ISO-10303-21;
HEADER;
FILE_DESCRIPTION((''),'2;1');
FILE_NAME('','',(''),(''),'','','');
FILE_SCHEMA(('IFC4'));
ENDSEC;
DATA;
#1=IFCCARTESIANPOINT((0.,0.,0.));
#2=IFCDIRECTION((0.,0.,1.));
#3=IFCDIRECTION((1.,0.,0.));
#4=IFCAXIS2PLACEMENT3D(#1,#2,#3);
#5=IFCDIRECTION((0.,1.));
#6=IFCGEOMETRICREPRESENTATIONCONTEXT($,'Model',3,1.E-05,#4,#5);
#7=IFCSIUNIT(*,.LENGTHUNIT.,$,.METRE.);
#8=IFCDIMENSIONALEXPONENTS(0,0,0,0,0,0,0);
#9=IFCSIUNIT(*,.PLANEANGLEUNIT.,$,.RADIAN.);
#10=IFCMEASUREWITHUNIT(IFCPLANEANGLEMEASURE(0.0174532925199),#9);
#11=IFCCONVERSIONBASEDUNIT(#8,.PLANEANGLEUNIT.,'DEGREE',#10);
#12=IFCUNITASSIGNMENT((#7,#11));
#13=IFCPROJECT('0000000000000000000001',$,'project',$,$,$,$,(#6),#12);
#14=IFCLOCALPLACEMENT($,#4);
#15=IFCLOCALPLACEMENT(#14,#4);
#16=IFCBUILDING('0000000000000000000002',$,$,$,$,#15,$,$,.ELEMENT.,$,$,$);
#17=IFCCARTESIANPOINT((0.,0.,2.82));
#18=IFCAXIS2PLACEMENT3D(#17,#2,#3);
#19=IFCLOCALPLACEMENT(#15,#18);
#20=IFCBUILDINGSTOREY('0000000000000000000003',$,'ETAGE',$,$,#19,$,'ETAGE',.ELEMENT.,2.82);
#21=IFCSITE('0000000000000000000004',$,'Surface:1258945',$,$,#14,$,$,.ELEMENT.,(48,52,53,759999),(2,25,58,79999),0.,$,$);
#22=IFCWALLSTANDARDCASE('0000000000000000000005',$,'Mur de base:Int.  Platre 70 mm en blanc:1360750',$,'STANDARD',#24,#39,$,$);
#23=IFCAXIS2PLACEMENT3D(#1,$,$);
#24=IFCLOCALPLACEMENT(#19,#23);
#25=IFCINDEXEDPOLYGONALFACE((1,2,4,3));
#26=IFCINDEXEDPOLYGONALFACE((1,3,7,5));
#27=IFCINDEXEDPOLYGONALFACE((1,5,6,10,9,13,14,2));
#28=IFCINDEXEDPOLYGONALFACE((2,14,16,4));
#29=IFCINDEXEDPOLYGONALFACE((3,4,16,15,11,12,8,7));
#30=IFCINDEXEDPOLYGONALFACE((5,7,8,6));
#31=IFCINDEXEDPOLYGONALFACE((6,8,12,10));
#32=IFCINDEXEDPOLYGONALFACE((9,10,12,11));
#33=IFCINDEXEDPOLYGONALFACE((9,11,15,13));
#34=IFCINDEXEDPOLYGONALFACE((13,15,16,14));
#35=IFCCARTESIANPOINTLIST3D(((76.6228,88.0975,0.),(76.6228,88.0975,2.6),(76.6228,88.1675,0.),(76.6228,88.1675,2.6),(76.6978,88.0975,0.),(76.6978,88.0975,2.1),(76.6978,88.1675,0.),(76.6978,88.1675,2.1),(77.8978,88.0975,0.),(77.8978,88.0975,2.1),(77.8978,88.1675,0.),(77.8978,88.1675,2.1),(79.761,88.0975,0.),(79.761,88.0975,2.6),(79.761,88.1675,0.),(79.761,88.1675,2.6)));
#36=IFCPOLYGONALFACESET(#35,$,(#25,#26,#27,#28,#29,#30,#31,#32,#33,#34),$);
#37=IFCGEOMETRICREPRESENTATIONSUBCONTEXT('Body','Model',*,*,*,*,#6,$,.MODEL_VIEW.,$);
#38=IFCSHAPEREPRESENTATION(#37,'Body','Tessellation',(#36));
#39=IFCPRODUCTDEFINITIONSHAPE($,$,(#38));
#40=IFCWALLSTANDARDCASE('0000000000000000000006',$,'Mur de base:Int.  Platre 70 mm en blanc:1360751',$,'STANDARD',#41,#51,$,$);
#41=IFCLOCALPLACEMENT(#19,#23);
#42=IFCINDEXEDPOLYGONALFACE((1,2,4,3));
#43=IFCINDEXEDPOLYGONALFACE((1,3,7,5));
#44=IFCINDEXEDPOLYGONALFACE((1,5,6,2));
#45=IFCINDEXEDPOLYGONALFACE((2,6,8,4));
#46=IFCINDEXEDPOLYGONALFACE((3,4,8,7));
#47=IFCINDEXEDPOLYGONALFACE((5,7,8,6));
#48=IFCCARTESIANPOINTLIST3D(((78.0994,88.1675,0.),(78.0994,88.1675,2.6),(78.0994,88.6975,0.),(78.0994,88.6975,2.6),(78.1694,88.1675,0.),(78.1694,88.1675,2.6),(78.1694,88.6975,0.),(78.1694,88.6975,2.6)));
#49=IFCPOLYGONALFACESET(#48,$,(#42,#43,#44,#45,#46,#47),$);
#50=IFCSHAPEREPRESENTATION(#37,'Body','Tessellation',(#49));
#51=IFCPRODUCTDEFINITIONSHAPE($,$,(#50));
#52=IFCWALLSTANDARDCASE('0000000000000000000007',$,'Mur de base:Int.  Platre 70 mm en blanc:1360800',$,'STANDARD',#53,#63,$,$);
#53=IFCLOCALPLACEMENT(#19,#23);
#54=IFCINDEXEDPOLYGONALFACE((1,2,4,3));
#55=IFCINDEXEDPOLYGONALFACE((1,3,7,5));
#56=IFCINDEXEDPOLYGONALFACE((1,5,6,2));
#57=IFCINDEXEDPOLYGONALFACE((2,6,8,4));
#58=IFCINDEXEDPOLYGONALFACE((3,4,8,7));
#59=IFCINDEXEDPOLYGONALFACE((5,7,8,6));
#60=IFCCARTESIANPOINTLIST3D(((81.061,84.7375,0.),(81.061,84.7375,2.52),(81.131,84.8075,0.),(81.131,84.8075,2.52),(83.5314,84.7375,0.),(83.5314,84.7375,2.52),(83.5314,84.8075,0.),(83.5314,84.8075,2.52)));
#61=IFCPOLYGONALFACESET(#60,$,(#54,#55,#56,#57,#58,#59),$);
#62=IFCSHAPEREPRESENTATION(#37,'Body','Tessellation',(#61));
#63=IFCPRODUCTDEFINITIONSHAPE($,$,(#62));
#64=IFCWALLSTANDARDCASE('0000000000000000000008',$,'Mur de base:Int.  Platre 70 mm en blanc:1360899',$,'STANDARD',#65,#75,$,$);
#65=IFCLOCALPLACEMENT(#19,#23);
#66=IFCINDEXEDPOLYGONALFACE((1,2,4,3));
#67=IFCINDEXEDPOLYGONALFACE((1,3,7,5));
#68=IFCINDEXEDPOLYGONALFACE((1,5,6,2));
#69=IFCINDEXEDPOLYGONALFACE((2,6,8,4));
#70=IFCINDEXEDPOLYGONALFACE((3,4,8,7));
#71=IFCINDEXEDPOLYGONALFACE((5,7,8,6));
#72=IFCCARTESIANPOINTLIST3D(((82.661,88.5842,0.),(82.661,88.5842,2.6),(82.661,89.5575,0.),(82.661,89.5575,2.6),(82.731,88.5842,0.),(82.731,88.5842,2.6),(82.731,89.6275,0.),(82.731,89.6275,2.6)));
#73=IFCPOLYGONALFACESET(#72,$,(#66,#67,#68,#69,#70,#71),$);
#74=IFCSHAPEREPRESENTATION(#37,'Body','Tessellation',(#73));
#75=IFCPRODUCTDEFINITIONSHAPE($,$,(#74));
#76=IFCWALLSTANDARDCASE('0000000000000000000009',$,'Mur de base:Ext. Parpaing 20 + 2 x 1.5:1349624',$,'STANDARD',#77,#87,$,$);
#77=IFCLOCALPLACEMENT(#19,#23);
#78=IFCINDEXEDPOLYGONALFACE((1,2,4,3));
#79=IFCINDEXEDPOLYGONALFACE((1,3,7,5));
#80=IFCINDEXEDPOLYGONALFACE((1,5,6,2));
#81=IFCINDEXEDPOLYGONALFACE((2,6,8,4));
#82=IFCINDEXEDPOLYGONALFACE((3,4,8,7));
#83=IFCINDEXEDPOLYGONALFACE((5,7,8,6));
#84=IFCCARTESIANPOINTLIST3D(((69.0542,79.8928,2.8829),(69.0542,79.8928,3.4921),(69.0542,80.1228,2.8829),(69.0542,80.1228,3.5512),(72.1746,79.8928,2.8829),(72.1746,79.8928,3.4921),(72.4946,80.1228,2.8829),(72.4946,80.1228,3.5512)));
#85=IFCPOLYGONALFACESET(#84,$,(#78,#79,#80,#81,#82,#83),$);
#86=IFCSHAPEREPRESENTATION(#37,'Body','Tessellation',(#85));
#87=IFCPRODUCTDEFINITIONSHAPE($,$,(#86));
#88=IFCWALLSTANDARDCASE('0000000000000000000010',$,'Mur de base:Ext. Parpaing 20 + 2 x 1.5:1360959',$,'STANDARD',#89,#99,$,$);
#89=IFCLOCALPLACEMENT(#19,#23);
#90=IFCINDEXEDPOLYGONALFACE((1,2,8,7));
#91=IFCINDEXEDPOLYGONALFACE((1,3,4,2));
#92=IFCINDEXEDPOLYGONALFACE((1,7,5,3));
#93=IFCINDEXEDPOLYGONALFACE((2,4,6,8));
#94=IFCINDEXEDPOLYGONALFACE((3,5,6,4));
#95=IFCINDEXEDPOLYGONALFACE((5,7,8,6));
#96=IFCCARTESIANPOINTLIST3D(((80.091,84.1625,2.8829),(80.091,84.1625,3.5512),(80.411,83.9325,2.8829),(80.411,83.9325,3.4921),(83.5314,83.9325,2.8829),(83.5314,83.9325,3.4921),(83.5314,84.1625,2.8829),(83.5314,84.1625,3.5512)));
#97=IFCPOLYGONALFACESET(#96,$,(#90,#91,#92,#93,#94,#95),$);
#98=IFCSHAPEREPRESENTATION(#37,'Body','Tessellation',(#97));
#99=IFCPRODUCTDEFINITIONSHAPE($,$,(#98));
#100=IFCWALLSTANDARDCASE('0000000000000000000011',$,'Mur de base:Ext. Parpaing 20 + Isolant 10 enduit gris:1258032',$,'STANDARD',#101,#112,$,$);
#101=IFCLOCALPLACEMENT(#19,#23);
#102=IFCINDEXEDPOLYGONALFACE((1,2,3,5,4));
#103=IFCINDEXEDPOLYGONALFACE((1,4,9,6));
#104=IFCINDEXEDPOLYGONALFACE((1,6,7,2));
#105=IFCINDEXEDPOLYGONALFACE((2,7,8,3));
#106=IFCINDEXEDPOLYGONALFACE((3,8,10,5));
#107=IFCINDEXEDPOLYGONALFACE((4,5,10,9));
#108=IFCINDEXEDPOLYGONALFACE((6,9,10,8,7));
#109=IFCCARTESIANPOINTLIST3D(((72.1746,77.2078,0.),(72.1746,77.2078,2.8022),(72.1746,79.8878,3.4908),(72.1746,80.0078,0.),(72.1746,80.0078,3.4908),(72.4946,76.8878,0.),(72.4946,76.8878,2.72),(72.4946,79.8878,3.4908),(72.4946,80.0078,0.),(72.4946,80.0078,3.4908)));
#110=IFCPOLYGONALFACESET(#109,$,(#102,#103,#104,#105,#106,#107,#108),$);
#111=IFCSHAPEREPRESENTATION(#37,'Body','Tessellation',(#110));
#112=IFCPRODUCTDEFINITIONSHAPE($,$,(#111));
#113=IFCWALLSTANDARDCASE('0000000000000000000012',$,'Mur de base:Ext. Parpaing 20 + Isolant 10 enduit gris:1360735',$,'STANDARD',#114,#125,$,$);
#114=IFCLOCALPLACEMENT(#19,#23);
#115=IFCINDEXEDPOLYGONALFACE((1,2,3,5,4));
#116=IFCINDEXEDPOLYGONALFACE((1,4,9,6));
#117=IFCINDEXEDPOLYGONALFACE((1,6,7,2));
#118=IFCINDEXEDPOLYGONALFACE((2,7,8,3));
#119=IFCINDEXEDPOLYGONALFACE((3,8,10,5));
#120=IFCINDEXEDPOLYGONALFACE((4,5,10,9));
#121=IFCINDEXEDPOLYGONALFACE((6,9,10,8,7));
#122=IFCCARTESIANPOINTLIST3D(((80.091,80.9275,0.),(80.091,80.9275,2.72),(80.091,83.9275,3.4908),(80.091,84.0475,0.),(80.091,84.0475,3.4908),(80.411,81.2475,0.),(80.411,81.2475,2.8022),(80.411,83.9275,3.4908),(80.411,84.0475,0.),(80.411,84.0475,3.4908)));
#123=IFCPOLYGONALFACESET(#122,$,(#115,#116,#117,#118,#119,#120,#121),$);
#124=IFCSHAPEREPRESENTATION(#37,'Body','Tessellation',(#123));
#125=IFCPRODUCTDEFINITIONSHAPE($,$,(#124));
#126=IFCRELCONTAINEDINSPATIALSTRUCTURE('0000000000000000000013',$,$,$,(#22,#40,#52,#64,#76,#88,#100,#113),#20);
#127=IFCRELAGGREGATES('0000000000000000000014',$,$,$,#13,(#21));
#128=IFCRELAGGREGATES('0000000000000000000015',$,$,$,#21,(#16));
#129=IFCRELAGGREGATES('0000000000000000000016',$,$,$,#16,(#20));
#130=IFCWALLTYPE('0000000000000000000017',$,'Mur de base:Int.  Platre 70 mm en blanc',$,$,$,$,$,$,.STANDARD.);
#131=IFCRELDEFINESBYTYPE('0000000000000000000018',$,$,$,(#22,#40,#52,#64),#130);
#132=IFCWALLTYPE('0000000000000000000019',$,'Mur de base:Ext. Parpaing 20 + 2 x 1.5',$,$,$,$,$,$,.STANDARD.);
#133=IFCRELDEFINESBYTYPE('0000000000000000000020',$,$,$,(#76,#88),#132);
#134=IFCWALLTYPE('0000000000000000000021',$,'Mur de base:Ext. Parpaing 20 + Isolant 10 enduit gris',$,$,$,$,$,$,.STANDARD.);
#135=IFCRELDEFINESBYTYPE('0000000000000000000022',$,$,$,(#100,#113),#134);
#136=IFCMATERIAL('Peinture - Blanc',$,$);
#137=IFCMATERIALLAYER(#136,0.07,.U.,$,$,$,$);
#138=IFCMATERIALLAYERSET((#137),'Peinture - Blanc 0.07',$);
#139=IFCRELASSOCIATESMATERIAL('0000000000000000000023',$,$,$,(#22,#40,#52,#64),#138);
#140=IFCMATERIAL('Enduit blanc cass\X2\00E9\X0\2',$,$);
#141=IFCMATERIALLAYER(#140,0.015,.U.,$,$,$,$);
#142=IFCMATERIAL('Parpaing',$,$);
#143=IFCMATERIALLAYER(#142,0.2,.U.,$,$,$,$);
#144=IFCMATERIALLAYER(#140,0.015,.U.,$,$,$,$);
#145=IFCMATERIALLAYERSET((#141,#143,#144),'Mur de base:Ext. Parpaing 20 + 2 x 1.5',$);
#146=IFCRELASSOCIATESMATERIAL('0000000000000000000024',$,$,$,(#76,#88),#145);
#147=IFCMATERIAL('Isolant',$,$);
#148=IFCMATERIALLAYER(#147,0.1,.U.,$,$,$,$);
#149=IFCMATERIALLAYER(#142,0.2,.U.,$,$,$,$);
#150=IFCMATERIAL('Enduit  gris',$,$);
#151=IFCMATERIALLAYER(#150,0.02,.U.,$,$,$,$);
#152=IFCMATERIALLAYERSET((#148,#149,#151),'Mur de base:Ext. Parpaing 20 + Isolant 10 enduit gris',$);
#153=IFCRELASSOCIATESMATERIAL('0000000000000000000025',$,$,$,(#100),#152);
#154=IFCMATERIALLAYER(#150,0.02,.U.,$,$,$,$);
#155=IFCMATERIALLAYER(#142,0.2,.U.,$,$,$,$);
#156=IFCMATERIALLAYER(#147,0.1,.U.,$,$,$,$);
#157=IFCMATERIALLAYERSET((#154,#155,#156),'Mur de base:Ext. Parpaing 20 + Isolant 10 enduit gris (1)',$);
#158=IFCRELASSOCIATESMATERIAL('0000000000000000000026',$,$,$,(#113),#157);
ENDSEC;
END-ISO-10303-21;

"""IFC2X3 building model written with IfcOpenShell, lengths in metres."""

from ifc_helpers import new_model, entity, si_unit, converted_unit, direction, frame, origin_with_axes, place, context, subcontext, project, spatial, polyline, outline, extrude, clip, halfspace, material, layer, layer_set, layer_usage, type_object, element, save


model = new_model("IFC2X3")

# Units and contexts
model_context = context("Model", 3, precision=1e-05, world=origin_with_axes(), true_north=direction((0.0, 1.0)))
body_context = subcontext(model_context, "Body", "Model", "MODEL_VIEW")
ifc_project = project(units=[si_unit("LENGTHUNIT", "METRE"), converted_unit("PLANEANGLEUNIT", "DEGREE", entity("IfcPlaneAngleMeasure", 0.0174532925199), si_unit("PLANEANGLEUNIT", "RADIAN"), dimensions=[0, 0, 0, 0, 0, 0, 0])], contexts=[model_context])

# Site, building, storey
site_placement = place(None, origin_with_axes())
site = spatial("IfcSite", under=ifc_project, at=site_placement, Name="Surface:1258945", CompositionType="ELEMENT", RefLatitude=(48, 52, 53, 759999), RefLongitude=(2, 25, 58, 79999), RefElevation=0.0)
building_placement = place(site_placement, origin_with_axes())
building = spatial("IfcBuilding", under=site, at=building_placement, CompositionType="ELEMENT")
storey_placement = place(building_placement, frame((0.0, 0.0, 2.82), z_axis=(0.0, 0.0, 1.0), x_axis=(1.0, 0.0, 0.0)))
storey = spatial("IfcBuildingStorey", under=building, at=storey_placement, Name="ETAGE", LongName="ETAGE", CompositionType="ELEMENT", Elevation=2.82)

# Shared definitions
ifc_material_1 = material(Name="Isolant")
ifc_material_2 = material(Name="Parpaing")
ifc_material_3 = material(Name="Enduit blanc cassé2")

# Shared definitions
ifc_material_4 = material(Name="Peinture - Blanc")
ifc_layer_1 = layer(ifc_material_4, 0.07, ventilated="UNKNOWN")
ifc_layer_set_1 = layer_set([ifc_layer_1], Name="Peinture - Blanc 0.07")
wall_type_1 = type_object("IfcWallType", Name="Mur de base:Int.  Platre 70 mm en blanc", PredefinedType="STANDARD")

# Wall, opening
ifc_layer_usage_1 = layer_usage(ifc_layer_set_1, "AXIS2", "POSITIVE", -0.035)
wall_1_placement = place(storey_placement, frame((79.796, 88.1325, 0.0), z_axis=(0.0, 0.0, 1.0), x_axis=(-1.0, 0.0, 0.0)))
wall_1 = element("IfcWallStandardCase", 1, at=wall_1_placement, inside=storey, type_object=wall_type_1, material=ifc_layer_usage_1, Name="Mur de base:Int.  Platre 70 mm en blanc:1360750", ObjectType="STANDARD", context=body_context, shape_type="SweptSolid", body=[
    extrude(outline(polyline([(0.035, -0.035), (3.1733, -0.035), (3.1733, 0.035), (0.035, 0.035), (0.035, -0.035)])), origin_with_axes(), (0.0, 0.0, 1.0), 2.6),
])
opening_1_placement = place(wall_1_placement, frame((2.4983, 0.0, 0.0), z_axis=(0.0, 0.0, 1.0), x_axis=(1.0, 0.0, 0.0)))
element("IfcOpeningElement", 2, at=opening_1_placement, cuts=wall_1, context=body_context, shape_type="SweptSolid", body=[
    extrude(outline(polyline([(0.6, 0.0), (0.6, 2.1), (-0.6, 2.1), (-0.6, 0.0), (0.6, 0.0)])), frame((0.0, 0.035, 0.0), z_axis=(0.0, -1.0, 0.0), x_axis=(1.0, 0.0, 0.0)), (0.0, 0.0, 1.0), 0.07),
])

# Walls
ifc_layer_usage_2 = layer_usage(ifc_layer_set_1, "AXIS2", "POSITIVE", -0.035)
wall_2_placement = place(storey_placement, frame((78.1344, 88.1325, 0.0), z_axis=(0.0, 0.0, 1.0), x_axis=(0.0, 1.0, 0.0)))
element("IfcWallStandardCase", 3, at=wall_2_placement, inside=storey, type_object=wall_type_1, material=ifc_layer_usage_2, Name="Mur de base:Int.  Platre 70 mm en blanc:1360751", ObjectType="STANDARD", context=body_context, shape_type="SweptSolid", body=[
    extrude(outline(polyline([(0.035, -0.035), (0.565, -0.035), (0.565, 0.035), (0.035, 0.035), (0.035, -0.035)])), origin_with_axes(), (0.0, 0.0, 1.0), 2.6),
])
ifc_layer_usage_3 = layer_usage(ifc_layer_set_1, "AXIS2", "POSITIVE", -0.035)
wall_3_placement = place(storey_placement, frame((81.096, 84.7725, 0.0), z_axis=(0.0, 0.0, 1.0), x_axis=(1.0, 0.0, 0.0)))
element("IfcWallStandardCase", 4, at=wall_3_placement, inside=storey, type_object=wall_type_1, material=ifc_layer_usage_3, Name="Mur de base:Int.  Platre 70 mm en blanc:1360800", ObjectType="STANDARD", context=body_context, shape_type="SweptSolid", body=[
    extrude(outline(polyline([(-0.035, -0.035), (2.4354, -0.035), (2.4354, 0.035), (0.035, 0.035), (-0.035, -0.035)])), origin_with_axes(), (0.0, 0.0, 1.0), 2.52),
])
ifc_layer_usage_4 = layer_usage(ifc_layer_set_1, "AXIS2", "POSITIVE", -0.035)
wall_4_placement = place(storey_placement, frame((82.696, 88.5492, 0.0), z_axis=(0.0, 0.0, 1.0), x_axis=(0.0, 1.0, 0.0)))
element("IfcWallStandardCase", 5, at=wall_4_placement, inside=storey, type_object=wall_type_1, material=ifc_layer_usage_4, Name="Mur de base:Int.  Platre 70 mm en blanc:1360899", ObjectType="STANDARD", context=body_context, shape_type="SweptSolid", body=[
    extrude(outline(polyline([(0.035, -0.035), (1.0783, -0.035), (1.0083, 0.035), (0.035, 0.035), (0.035, -0.035)])), origin_with_axes(), (0.0, 0.0, 1.0), 2.6),
])
ifc_layer_2 = layer(ifc_material_3, 0.015, ventilated="UNKNOWN")
ifc_layer_3 = layer(ifc_material_2, 0.2, ventilated="UNKNOWN")
ifc_layer_4 = layer(ifc_material_3, 0.015, ventilated="UNKNOWN")
ifc_layer_set_2 = layer_set([ifc_layer_2, ifc_layer_3, ifc_layer_4], Name="Mur de base:Ext. Parpaing 20 + 2 x 1.5")
ifc_layer_usage_5 = layer_usage(ifc_layer_set_2, "AXIS2", "POSITIVE", -0.115)
wall_type_2 = type_object("IfcWallType", Name="Mur de base:Ext. Parpaing 20 + 2 x 1.5", PredefinedType="STANDARD")
wall_5_placement = place(storey_placement, frame((72.3346, 80.0078, 2.8829), z_axis=(0.0, 0.0, 1.0), x_axis=(-1.0, 0.0, 0.0)))
element("IfcWallStandardCase", 6, at=wall_5_placement, inside=storey, type_object=wall_type_2, material=ifc_layer_usage_5, Name="Mur de base:Ext. Parpaing 20 + 2 x 1.5:1349624", ObjectType="STANDARD", context=body_context, shape_type="Clipping", body=[
    clip(extrude(outline(polyline([(-0.16, -0.115), (3.2804, -0.115), (3.2804, 0.115), (0.16, 0.115), (-0.16, -0.115)])), origin_with_axes(), (0.0, 0.0, 1.0), 0.6683), halfspace(frame((0.0, 0.154, 0.5992), z_axis=(0.0, -0.248865, -0.968538), x_axis=(0.0, 0.968538, -0.248865)), True)),
])
ifc_layer_usage_6 = layer_usage(ifc_layer_set_2, "AXIS2", "POSITIVE", -0.115)
wall_6_placement = place(storey_placement, frame((80.251, 84.0475, 2.8829), z_axis=(0.0, 0.0, 1.0), x_axis=(1.0, 0.0, 0.0)))
element("IfcWallStandardCase", 7, at=wall_6_placement, inside=storey, type_object=wall_type_2, material=ifc_layer_usage_6, Name="Mur de base:Ext. Parpaing 20 + 2 x 1.5:1360959", ObjectType="STANDARD", context=body_context, shape_type="Clipping", body=[
    clip(extrude(outline(polyline([(0.16, -0.115), (3.2804, -0.115), (3.2804, 0.115), (-0.16, 0.115), (0.16, -0.115)])), origin_with_axes(), (0.0, 0.0, 1.0), 0.6683), halfspace(frame((0.0, -0.154, 0.5992), z_axis=(0.0, 0.248865, -0.968538), x_axis=(0.0, 0.968538, 0.248865)), True)),
])
ifc_layer_5 = layer(ifc_material_1, 0.1, ventilated="UNKNOWN")
ifc_layer_6 = layer(ifc_material_2, 0.2, ventilated="UNKNOWN")
ifc_material_5 = material(Name="Enduit  gris")
ifc_layer_7 = layer(ifc_material_5, 0.02, ventilated="UNKNOWN")
ifc_layer_set_3 = layer_set([ifc_layer_5, ifc_layer_6, ifc_layer_7], Name="Mur de base:Ext. Parpaing 20 + Isolant 10 enduit gris")
ifc_layer_usage_7 = layer_usage(ifc_layer_set_3, "AXIS2", "POSITIVE", -0.16)
wall_type_3 = type_object("IfcWallType", Name="Mur de base:Ext. Parpaing 20 + Isolant 10 enduit gris", PredefinedType="STANDARD")
wall_7_placement = place(storey_placement, frame((72.3346, 80.0078, 0.0), z_axis=(0.0, 0.0, 1.0), x_axis=(0.0, -1.0, 0.0)))
element("IfcWallStandardCase", 8, at=wall_7_placement, inside=storey, type_object=wall_type_3, material=ifc_layer_usage_7, Name="Mur de base:Ext. Parpaing 20 + Isolant 10 enduit gris:1258032", ObjectType="STANDARD", context=body_context, shape_type="Clipping", body=[
    clip(extrude(outline(polyline([(0.0, -0.16), (2.8, -0.16), (3.12, 0.16), (0.0, 0.16), (0.0, -0.16)])), origin_with_axes(), (0.0, 0.0, 1.0), 3.4908), halfspace(frame((0.8488, 0.0, 3.3036), z_axis=(-0.248865, 0.0, -0.968538), x_axis=(0.0, 1.0, 0.0)), True)),
])
ifc_layer_8 = layer(ifc_material_5, 0.02, ventilated="UNKNOWN")
ifc_layer_9 = layer(ifc_material_2, 0.2, ventilated="UNKNOWN")
ifc_layer_10 = layer(ifc_material_1, 0.1, ventilated="UNKNOWN")
ifc_layer_set_4 = layer_set([ifc_layer_8, ifc_layer_9, ifc_layer_10], Name="Mur de base:Ext. Parpaing 20 + Isolant 10 enduit gris (1)")
ifc_layer_usage_8 = layer_usage(ifc_layer_set_4, "AXIS2", "POSITIVE", -0.16)
wall_8_placement = place(storey_placement, frame((80.251, 84.0475, 0.0), z_axis=(0.0, 0.0, 1.0), x_axis=(0.0, -1.0, 0.0)))
element("IfcWallStandardCase", 9, at=wall_8_placement, inside=storey, type_object=wall_type_3, material=ifc_layer_usage_8, Name="Mur de base:Ext. Parpaing 20 + Isolant 10 enduit gris:1360735", ObjectType="STANDARD", context=body_context, shape_type="Clipping", body=[
    clip(extrude(outline(polyline([(0.0, -0.16), (3.12, -0.16), (2.8, 0.16), (0.0, 0.16), (0.0, -0.16)])), origin_with_axes(), (0.0, 0.0, 1.0), 3.4908), halfspace(frame((0.8488, 0.0, 3.3036), z_axis=(-0.248865, 0.0, -0.968538), x_axis=(0.0, 1.0, 0.0)), True)),
])

save(model, "model.ifc")
